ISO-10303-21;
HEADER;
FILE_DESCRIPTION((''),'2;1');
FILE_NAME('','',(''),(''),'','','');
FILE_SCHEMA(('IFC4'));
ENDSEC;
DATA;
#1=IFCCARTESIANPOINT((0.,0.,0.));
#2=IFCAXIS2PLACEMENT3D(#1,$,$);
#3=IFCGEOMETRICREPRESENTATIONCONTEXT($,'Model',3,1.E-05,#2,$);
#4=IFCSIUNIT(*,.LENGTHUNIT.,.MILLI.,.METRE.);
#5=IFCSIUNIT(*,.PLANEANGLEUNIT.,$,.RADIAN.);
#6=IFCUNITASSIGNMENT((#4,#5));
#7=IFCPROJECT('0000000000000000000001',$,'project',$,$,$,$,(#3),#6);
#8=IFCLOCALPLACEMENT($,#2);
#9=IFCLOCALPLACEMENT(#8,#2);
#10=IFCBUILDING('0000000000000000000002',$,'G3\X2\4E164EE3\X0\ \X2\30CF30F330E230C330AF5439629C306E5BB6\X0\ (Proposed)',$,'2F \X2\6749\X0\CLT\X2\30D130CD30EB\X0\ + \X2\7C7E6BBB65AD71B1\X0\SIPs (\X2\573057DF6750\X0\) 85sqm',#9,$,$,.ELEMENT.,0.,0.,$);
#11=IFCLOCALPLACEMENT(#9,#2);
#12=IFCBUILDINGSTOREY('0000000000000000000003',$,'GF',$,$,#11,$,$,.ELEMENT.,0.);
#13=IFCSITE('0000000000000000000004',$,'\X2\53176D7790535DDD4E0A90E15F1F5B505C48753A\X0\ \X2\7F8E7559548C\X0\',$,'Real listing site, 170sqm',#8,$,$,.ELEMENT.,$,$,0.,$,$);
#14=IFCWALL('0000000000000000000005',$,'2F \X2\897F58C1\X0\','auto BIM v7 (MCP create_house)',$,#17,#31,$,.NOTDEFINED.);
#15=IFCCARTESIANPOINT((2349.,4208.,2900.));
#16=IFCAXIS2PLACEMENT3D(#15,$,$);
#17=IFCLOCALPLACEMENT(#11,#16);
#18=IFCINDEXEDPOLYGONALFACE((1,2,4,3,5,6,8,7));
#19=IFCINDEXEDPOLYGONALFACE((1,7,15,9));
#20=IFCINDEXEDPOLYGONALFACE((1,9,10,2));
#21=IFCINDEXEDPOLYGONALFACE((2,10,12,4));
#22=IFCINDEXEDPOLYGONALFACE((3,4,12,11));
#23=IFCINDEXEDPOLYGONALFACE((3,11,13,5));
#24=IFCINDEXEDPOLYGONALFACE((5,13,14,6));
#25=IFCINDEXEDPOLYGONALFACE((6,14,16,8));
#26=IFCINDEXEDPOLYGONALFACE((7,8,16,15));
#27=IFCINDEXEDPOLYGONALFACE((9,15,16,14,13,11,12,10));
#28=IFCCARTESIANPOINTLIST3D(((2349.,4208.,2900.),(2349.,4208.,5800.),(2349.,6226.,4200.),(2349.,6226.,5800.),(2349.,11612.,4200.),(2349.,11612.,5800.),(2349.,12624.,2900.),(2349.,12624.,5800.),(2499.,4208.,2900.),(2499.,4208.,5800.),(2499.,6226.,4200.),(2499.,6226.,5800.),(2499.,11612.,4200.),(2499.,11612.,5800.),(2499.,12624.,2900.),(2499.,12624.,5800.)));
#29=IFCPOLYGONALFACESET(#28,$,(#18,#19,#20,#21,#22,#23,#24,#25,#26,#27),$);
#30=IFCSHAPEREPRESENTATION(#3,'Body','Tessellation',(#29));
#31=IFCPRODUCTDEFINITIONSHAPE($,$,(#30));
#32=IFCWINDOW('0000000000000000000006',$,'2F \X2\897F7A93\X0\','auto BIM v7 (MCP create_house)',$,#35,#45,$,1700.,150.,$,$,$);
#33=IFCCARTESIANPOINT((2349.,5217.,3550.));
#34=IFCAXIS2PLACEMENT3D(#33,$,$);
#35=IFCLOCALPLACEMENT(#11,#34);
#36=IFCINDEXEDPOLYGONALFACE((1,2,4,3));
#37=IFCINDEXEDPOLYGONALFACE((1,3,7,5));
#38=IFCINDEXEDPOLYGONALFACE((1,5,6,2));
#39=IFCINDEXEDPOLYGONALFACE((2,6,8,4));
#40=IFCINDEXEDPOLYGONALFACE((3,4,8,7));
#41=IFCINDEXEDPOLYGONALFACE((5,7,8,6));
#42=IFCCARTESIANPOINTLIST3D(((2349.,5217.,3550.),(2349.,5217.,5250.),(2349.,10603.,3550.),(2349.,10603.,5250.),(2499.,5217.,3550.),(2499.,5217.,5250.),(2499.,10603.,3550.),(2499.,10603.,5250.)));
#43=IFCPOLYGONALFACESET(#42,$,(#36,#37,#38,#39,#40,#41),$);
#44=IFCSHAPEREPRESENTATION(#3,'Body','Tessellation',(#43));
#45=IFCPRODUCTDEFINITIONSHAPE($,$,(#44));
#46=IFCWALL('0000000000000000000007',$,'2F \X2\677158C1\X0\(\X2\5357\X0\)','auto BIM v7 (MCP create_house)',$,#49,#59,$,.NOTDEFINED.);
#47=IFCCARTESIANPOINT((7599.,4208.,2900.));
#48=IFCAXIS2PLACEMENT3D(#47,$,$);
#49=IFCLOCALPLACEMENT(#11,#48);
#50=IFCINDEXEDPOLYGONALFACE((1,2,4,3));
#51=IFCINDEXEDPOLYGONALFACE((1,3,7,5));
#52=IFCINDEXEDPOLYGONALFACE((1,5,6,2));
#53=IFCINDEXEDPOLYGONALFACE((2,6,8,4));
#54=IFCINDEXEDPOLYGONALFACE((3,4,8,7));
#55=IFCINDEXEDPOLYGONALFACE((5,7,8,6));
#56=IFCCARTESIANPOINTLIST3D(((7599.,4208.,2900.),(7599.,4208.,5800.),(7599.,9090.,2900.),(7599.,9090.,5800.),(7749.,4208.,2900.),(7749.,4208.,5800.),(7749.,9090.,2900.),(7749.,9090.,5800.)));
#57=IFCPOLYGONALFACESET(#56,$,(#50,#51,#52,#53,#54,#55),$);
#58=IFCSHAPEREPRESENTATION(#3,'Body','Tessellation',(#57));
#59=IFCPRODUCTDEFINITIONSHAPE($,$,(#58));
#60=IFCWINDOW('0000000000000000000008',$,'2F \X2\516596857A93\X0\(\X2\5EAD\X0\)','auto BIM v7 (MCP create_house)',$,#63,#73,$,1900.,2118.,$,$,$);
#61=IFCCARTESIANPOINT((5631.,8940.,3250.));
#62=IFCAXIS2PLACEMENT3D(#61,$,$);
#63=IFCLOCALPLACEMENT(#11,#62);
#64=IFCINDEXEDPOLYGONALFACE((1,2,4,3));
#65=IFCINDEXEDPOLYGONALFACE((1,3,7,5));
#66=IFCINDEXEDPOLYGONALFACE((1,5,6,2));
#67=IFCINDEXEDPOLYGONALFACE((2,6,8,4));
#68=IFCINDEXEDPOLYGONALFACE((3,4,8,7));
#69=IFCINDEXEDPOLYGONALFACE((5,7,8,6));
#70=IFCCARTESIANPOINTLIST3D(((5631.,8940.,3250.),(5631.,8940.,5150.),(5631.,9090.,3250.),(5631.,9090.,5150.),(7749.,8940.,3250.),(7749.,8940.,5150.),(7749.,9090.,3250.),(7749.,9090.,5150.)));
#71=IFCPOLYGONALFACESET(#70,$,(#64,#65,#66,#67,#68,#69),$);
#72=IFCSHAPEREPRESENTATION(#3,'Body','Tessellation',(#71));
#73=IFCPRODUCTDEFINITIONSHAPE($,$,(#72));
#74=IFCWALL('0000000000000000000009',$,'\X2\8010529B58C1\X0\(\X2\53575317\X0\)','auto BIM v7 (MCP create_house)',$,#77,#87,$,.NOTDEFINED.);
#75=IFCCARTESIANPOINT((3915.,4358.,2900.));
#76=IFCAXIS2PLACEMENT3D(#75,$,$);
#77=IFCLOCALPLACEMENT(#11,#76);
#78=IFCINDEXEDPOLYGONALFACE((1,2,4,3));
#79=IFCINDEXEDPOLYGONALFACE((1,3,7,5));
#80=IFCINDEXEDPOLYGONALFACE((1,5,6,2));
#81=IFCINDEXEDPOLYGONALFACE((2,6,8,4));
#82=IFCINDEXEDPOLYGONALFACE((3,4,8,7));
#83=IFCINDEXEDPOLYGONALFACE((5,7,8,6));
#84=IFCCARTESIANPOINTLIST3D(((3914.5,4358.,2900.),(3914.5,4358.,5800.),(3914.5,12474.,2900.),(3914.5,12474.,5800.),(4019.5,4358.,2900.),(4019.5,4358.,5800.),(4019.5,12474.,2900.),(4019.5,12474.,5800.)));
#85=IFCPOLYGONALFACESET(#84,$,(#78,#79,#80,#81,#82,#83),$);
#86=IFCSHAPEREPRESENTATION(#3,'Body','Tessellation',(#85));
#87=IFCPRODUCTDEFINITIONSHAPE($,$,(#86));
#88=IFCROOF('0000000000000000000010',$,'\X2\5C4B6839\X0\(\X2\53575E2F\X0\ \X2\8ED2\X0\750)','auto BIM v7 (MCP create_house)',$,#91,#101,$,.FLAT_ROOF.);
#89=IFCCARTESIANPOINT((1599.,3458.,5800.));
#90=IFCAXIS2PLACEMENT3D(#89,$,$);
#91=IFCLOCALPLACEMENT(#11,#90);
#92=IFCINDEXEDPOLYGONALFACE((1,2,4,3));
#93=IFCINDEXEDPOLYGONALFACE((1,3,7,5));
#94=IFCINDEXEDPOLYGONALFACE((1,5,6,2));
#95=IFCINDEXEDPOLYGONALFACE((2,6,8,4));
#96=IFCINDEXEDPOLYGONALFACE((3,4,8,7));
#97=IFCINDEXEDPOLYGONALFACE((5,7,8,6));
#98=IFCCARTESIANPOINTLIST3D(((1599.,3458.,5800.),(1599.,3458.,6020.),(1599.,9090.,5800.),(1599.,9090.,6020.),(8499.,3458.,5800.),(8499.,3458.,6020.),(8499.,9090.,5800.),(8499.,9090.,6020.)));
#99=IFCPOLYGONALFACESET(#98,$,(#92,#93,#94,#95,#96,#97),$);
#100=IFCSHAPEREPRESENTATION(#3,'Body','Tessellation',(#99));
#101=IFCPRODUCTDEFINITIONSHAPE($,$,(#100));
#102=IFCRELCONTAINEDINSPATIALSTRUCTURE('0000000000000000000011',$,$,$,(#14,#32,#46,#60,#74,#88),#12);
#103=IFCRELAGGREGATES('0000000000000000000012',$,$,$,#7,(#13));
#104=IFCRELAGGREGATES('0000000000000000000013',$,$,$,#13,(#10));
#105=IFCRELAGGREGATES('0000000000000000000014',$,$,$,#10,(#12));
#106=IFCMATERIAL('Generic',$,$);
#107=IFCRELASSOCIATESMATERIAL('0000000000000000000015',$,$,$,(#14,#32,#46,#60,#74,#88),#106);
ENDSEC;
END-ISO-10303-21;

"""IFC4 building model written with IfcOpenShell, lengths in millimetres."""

from ifc_helpers import new_model, si_unit, frame, frame_2d, origin, place, context, project, spatial, rectangle, extrude, material, element, fill, save


model = new_model("IFC4")

# Units and contexts
model_context = context("Model", 3, precision=1e-05, world=origin())
ifc_project = project(units=[si_unit("LENGTHUNIT", "METRE", prefix="MILLI"), si_unit("PLANEANGLEUNIT", "RADIAN")], contexts=[model_context])

# Site, building, storey
site_placement = place(None, origin())
site = spatial("IfcSite", under=ifc_project, at=site_placement, Name="北海道川上郡弟子屈町 美留和", ObjectType="Real listing site, 170sqm", CompositionType="ELEMENT", RefElevation=0.0)
building_placement = place(site_placement, origin())
building = spatial("IfcBuilding", under=site, at=building_placement, Name="G3世代 ハンモック吹抜の家 (Proposed)", ObjectType="2F 杉CLTパネル + 籾殻断熱SIPs (地域材) 85sqm", CompositionType="ELEMENT", ElevationOfRefHeight=0.0, ElevationOfTerrain=0.0)
storey_placement = place(building_placement, origin())
storey = spatial("IfcBuildingStorey", under=building, at=storey_placement, Name="GF", CompositionType="ELEMENT", Elevation=0.0)

# Shared definitions
ifc_material = material(Name="Generic")

# Walls, openings, windows
wall_1_placement = place(storey_placement, frame((2349.0, 4208.0, 2900.0)))
wall_1 = element("IfcWall", 1, at=wall_1_placement, inside=storey, material=ifc_material, Name="2F 西壁", Description="auto BIM v7 (MCP create_house)", PredefinedType="NOTDEFINED", context=model_context, shape_type="SweptSolid", body=[
    extrude(rectangle(XDim=150.0, YDim=8416.0, at=frame_2d((75.0, 4208.0))), frame((2349.0, 4208.0, 2900.0)), (0.0, 0.0, 1.0), 2900.0),
])
opening_1_placement = place(storey_placement, frame((2349.0, 5217.0, 3550.0)))
opening_1 = element("IfcOpeningElement", 2, at=opening_1_placement, cuts=wall_1, PredefinedType="NOTDEFINED", context=model_context, shape_type="SweptSolid", body=[
    extrude(rectangle(XDim=150.0, YDim=5386.0, at=frame_2d((75.0, 2693.0))), frame((2349.0, 5217.0, 3550.0)), (0.0, 0.0, 1.0), 1700.0),
])
window_1_placement = place(storey_placement, frame((2349.0, 5217.0, 3550.0)))
window_1 = element("IfcWindow", 3, at=window_1_placement, inside=storey, material=ifc_material, Name="2F 西窓", Description="auto BIM v7 (MCP create_house)", OverallHeight=1700.0, OverallWidth=150.0, context=model_context, shape_type="SweptSolid", body=[
    extrude(rectangle(XDim=150.0, YDim=5386.0, at=frame_2d((75.0, 2693.0))), frame((2349.0, 5217.0, 3550.0)), (0.0, 0.0, 1.0), 1700.0),
])
fill(opening_1, window_1)
wall_2_placement = place(storey_placement, frame((7599.0, 4208.0, 2900.0)))
wall_2 = element("IfcWall", 4, at=wall_2_placement, inside=storey, material=ifc_material, Name="2F 東壁(南)", Description="auto BIM v7 (MCP create_house)", PredefinedType="NOTDEFINED", context=model_context, shape_type="SweptSolid", body=[
    extrude(rectangle(XDim=150.0, YDim=4882.0, at=frame_2d((75.0, 2441.0))), frame((7599.0, 4208.0, 2900.0)), (0.0, 0.0, 1.0), 2900.0),
])
opening_2_placement = place(storey_placement, frame((5631.0, 8940.0, 3250.0)))
opening_2 = element("IfcOpeningElement", 5, at=opening_2_placement, cuts=wall_2, PredefinedType="NOTDEFINED", context=model_context, shape_type="SweptSolid", body=[
    extrude(rectangle(XDim=2118.0, YDim=150.0, at=frame_2d((1059.0, 75.0))), frame((5631.0, 8940.0, 3250.0)), (0.0, 0.0, 1.0), 1900.0),
])
window_2_placement = place(storey_placement, frame((5631.0, 8940.0, 3250.0)))
window_2 = element("IfcWindow", 6, at=window_2_placement, inside=storey, material=ifc_material, Name="2F 入隅窓(庭)", Description="auto BIM v7 (MCP create_house)", OverallHeight=1900.0, OverallWidth=2118.0, context=model_context, shape_type="SweptSolid", body=[
    extrude(rectangle(XDim=2118.0, YDim=150.0, at=frame_2d((1059.0, 75.0))), frame((5631.0, 8940.0, 3250.0)), (0.0, 0.0, 1.0), 1900.0),
])
fill(opening_2, window_2)

# Wall
wall_3_placement = place(storey_placement, frame((3915.0, 4358.0, 2900.0)))
element("IfcWall", 7, at=wall_3_placement, inside=storey, material=ifc_material, Name="耐力壁(南北)", Description="auto BIM v7 (MCP create_house)", PredefinedType="NOTDEFINED", context=model_context, shape_type="SweptSolid", body=[
    extrude(rectangle(XDim=105.0, YDim=8116.0, at=frame_2d((52.0, 4058.0))), frame((3915.0, 4358.0, 2900.0)), (0.0, 0.0, 1.0), 2900.0),
])

# Roof
for number, where, name in (
    (8, (1599.0, 3458.0, 5800.0), "屋根(南帯 軒750)"),
):
    element("IfcRoof", number, at=place(storey_placement, frame(where)), inside=storey, material=ifc_material, Name=name, Description="auto BIM v7 (MCP create_house)", PredefinedType="FLAT_ROOF", context=model_context, shape_type="SweptSolid", body=[
        extrude(rectangle(XDim=6900.0, YDim=5632.0, at=frame_2d((3450.0, 2816.0))), frame((1599.0, 3458.0, 5800.0)), (0.0, 0.0, 1.0), 220.0),
    ])

save(model, "model.ifc")
